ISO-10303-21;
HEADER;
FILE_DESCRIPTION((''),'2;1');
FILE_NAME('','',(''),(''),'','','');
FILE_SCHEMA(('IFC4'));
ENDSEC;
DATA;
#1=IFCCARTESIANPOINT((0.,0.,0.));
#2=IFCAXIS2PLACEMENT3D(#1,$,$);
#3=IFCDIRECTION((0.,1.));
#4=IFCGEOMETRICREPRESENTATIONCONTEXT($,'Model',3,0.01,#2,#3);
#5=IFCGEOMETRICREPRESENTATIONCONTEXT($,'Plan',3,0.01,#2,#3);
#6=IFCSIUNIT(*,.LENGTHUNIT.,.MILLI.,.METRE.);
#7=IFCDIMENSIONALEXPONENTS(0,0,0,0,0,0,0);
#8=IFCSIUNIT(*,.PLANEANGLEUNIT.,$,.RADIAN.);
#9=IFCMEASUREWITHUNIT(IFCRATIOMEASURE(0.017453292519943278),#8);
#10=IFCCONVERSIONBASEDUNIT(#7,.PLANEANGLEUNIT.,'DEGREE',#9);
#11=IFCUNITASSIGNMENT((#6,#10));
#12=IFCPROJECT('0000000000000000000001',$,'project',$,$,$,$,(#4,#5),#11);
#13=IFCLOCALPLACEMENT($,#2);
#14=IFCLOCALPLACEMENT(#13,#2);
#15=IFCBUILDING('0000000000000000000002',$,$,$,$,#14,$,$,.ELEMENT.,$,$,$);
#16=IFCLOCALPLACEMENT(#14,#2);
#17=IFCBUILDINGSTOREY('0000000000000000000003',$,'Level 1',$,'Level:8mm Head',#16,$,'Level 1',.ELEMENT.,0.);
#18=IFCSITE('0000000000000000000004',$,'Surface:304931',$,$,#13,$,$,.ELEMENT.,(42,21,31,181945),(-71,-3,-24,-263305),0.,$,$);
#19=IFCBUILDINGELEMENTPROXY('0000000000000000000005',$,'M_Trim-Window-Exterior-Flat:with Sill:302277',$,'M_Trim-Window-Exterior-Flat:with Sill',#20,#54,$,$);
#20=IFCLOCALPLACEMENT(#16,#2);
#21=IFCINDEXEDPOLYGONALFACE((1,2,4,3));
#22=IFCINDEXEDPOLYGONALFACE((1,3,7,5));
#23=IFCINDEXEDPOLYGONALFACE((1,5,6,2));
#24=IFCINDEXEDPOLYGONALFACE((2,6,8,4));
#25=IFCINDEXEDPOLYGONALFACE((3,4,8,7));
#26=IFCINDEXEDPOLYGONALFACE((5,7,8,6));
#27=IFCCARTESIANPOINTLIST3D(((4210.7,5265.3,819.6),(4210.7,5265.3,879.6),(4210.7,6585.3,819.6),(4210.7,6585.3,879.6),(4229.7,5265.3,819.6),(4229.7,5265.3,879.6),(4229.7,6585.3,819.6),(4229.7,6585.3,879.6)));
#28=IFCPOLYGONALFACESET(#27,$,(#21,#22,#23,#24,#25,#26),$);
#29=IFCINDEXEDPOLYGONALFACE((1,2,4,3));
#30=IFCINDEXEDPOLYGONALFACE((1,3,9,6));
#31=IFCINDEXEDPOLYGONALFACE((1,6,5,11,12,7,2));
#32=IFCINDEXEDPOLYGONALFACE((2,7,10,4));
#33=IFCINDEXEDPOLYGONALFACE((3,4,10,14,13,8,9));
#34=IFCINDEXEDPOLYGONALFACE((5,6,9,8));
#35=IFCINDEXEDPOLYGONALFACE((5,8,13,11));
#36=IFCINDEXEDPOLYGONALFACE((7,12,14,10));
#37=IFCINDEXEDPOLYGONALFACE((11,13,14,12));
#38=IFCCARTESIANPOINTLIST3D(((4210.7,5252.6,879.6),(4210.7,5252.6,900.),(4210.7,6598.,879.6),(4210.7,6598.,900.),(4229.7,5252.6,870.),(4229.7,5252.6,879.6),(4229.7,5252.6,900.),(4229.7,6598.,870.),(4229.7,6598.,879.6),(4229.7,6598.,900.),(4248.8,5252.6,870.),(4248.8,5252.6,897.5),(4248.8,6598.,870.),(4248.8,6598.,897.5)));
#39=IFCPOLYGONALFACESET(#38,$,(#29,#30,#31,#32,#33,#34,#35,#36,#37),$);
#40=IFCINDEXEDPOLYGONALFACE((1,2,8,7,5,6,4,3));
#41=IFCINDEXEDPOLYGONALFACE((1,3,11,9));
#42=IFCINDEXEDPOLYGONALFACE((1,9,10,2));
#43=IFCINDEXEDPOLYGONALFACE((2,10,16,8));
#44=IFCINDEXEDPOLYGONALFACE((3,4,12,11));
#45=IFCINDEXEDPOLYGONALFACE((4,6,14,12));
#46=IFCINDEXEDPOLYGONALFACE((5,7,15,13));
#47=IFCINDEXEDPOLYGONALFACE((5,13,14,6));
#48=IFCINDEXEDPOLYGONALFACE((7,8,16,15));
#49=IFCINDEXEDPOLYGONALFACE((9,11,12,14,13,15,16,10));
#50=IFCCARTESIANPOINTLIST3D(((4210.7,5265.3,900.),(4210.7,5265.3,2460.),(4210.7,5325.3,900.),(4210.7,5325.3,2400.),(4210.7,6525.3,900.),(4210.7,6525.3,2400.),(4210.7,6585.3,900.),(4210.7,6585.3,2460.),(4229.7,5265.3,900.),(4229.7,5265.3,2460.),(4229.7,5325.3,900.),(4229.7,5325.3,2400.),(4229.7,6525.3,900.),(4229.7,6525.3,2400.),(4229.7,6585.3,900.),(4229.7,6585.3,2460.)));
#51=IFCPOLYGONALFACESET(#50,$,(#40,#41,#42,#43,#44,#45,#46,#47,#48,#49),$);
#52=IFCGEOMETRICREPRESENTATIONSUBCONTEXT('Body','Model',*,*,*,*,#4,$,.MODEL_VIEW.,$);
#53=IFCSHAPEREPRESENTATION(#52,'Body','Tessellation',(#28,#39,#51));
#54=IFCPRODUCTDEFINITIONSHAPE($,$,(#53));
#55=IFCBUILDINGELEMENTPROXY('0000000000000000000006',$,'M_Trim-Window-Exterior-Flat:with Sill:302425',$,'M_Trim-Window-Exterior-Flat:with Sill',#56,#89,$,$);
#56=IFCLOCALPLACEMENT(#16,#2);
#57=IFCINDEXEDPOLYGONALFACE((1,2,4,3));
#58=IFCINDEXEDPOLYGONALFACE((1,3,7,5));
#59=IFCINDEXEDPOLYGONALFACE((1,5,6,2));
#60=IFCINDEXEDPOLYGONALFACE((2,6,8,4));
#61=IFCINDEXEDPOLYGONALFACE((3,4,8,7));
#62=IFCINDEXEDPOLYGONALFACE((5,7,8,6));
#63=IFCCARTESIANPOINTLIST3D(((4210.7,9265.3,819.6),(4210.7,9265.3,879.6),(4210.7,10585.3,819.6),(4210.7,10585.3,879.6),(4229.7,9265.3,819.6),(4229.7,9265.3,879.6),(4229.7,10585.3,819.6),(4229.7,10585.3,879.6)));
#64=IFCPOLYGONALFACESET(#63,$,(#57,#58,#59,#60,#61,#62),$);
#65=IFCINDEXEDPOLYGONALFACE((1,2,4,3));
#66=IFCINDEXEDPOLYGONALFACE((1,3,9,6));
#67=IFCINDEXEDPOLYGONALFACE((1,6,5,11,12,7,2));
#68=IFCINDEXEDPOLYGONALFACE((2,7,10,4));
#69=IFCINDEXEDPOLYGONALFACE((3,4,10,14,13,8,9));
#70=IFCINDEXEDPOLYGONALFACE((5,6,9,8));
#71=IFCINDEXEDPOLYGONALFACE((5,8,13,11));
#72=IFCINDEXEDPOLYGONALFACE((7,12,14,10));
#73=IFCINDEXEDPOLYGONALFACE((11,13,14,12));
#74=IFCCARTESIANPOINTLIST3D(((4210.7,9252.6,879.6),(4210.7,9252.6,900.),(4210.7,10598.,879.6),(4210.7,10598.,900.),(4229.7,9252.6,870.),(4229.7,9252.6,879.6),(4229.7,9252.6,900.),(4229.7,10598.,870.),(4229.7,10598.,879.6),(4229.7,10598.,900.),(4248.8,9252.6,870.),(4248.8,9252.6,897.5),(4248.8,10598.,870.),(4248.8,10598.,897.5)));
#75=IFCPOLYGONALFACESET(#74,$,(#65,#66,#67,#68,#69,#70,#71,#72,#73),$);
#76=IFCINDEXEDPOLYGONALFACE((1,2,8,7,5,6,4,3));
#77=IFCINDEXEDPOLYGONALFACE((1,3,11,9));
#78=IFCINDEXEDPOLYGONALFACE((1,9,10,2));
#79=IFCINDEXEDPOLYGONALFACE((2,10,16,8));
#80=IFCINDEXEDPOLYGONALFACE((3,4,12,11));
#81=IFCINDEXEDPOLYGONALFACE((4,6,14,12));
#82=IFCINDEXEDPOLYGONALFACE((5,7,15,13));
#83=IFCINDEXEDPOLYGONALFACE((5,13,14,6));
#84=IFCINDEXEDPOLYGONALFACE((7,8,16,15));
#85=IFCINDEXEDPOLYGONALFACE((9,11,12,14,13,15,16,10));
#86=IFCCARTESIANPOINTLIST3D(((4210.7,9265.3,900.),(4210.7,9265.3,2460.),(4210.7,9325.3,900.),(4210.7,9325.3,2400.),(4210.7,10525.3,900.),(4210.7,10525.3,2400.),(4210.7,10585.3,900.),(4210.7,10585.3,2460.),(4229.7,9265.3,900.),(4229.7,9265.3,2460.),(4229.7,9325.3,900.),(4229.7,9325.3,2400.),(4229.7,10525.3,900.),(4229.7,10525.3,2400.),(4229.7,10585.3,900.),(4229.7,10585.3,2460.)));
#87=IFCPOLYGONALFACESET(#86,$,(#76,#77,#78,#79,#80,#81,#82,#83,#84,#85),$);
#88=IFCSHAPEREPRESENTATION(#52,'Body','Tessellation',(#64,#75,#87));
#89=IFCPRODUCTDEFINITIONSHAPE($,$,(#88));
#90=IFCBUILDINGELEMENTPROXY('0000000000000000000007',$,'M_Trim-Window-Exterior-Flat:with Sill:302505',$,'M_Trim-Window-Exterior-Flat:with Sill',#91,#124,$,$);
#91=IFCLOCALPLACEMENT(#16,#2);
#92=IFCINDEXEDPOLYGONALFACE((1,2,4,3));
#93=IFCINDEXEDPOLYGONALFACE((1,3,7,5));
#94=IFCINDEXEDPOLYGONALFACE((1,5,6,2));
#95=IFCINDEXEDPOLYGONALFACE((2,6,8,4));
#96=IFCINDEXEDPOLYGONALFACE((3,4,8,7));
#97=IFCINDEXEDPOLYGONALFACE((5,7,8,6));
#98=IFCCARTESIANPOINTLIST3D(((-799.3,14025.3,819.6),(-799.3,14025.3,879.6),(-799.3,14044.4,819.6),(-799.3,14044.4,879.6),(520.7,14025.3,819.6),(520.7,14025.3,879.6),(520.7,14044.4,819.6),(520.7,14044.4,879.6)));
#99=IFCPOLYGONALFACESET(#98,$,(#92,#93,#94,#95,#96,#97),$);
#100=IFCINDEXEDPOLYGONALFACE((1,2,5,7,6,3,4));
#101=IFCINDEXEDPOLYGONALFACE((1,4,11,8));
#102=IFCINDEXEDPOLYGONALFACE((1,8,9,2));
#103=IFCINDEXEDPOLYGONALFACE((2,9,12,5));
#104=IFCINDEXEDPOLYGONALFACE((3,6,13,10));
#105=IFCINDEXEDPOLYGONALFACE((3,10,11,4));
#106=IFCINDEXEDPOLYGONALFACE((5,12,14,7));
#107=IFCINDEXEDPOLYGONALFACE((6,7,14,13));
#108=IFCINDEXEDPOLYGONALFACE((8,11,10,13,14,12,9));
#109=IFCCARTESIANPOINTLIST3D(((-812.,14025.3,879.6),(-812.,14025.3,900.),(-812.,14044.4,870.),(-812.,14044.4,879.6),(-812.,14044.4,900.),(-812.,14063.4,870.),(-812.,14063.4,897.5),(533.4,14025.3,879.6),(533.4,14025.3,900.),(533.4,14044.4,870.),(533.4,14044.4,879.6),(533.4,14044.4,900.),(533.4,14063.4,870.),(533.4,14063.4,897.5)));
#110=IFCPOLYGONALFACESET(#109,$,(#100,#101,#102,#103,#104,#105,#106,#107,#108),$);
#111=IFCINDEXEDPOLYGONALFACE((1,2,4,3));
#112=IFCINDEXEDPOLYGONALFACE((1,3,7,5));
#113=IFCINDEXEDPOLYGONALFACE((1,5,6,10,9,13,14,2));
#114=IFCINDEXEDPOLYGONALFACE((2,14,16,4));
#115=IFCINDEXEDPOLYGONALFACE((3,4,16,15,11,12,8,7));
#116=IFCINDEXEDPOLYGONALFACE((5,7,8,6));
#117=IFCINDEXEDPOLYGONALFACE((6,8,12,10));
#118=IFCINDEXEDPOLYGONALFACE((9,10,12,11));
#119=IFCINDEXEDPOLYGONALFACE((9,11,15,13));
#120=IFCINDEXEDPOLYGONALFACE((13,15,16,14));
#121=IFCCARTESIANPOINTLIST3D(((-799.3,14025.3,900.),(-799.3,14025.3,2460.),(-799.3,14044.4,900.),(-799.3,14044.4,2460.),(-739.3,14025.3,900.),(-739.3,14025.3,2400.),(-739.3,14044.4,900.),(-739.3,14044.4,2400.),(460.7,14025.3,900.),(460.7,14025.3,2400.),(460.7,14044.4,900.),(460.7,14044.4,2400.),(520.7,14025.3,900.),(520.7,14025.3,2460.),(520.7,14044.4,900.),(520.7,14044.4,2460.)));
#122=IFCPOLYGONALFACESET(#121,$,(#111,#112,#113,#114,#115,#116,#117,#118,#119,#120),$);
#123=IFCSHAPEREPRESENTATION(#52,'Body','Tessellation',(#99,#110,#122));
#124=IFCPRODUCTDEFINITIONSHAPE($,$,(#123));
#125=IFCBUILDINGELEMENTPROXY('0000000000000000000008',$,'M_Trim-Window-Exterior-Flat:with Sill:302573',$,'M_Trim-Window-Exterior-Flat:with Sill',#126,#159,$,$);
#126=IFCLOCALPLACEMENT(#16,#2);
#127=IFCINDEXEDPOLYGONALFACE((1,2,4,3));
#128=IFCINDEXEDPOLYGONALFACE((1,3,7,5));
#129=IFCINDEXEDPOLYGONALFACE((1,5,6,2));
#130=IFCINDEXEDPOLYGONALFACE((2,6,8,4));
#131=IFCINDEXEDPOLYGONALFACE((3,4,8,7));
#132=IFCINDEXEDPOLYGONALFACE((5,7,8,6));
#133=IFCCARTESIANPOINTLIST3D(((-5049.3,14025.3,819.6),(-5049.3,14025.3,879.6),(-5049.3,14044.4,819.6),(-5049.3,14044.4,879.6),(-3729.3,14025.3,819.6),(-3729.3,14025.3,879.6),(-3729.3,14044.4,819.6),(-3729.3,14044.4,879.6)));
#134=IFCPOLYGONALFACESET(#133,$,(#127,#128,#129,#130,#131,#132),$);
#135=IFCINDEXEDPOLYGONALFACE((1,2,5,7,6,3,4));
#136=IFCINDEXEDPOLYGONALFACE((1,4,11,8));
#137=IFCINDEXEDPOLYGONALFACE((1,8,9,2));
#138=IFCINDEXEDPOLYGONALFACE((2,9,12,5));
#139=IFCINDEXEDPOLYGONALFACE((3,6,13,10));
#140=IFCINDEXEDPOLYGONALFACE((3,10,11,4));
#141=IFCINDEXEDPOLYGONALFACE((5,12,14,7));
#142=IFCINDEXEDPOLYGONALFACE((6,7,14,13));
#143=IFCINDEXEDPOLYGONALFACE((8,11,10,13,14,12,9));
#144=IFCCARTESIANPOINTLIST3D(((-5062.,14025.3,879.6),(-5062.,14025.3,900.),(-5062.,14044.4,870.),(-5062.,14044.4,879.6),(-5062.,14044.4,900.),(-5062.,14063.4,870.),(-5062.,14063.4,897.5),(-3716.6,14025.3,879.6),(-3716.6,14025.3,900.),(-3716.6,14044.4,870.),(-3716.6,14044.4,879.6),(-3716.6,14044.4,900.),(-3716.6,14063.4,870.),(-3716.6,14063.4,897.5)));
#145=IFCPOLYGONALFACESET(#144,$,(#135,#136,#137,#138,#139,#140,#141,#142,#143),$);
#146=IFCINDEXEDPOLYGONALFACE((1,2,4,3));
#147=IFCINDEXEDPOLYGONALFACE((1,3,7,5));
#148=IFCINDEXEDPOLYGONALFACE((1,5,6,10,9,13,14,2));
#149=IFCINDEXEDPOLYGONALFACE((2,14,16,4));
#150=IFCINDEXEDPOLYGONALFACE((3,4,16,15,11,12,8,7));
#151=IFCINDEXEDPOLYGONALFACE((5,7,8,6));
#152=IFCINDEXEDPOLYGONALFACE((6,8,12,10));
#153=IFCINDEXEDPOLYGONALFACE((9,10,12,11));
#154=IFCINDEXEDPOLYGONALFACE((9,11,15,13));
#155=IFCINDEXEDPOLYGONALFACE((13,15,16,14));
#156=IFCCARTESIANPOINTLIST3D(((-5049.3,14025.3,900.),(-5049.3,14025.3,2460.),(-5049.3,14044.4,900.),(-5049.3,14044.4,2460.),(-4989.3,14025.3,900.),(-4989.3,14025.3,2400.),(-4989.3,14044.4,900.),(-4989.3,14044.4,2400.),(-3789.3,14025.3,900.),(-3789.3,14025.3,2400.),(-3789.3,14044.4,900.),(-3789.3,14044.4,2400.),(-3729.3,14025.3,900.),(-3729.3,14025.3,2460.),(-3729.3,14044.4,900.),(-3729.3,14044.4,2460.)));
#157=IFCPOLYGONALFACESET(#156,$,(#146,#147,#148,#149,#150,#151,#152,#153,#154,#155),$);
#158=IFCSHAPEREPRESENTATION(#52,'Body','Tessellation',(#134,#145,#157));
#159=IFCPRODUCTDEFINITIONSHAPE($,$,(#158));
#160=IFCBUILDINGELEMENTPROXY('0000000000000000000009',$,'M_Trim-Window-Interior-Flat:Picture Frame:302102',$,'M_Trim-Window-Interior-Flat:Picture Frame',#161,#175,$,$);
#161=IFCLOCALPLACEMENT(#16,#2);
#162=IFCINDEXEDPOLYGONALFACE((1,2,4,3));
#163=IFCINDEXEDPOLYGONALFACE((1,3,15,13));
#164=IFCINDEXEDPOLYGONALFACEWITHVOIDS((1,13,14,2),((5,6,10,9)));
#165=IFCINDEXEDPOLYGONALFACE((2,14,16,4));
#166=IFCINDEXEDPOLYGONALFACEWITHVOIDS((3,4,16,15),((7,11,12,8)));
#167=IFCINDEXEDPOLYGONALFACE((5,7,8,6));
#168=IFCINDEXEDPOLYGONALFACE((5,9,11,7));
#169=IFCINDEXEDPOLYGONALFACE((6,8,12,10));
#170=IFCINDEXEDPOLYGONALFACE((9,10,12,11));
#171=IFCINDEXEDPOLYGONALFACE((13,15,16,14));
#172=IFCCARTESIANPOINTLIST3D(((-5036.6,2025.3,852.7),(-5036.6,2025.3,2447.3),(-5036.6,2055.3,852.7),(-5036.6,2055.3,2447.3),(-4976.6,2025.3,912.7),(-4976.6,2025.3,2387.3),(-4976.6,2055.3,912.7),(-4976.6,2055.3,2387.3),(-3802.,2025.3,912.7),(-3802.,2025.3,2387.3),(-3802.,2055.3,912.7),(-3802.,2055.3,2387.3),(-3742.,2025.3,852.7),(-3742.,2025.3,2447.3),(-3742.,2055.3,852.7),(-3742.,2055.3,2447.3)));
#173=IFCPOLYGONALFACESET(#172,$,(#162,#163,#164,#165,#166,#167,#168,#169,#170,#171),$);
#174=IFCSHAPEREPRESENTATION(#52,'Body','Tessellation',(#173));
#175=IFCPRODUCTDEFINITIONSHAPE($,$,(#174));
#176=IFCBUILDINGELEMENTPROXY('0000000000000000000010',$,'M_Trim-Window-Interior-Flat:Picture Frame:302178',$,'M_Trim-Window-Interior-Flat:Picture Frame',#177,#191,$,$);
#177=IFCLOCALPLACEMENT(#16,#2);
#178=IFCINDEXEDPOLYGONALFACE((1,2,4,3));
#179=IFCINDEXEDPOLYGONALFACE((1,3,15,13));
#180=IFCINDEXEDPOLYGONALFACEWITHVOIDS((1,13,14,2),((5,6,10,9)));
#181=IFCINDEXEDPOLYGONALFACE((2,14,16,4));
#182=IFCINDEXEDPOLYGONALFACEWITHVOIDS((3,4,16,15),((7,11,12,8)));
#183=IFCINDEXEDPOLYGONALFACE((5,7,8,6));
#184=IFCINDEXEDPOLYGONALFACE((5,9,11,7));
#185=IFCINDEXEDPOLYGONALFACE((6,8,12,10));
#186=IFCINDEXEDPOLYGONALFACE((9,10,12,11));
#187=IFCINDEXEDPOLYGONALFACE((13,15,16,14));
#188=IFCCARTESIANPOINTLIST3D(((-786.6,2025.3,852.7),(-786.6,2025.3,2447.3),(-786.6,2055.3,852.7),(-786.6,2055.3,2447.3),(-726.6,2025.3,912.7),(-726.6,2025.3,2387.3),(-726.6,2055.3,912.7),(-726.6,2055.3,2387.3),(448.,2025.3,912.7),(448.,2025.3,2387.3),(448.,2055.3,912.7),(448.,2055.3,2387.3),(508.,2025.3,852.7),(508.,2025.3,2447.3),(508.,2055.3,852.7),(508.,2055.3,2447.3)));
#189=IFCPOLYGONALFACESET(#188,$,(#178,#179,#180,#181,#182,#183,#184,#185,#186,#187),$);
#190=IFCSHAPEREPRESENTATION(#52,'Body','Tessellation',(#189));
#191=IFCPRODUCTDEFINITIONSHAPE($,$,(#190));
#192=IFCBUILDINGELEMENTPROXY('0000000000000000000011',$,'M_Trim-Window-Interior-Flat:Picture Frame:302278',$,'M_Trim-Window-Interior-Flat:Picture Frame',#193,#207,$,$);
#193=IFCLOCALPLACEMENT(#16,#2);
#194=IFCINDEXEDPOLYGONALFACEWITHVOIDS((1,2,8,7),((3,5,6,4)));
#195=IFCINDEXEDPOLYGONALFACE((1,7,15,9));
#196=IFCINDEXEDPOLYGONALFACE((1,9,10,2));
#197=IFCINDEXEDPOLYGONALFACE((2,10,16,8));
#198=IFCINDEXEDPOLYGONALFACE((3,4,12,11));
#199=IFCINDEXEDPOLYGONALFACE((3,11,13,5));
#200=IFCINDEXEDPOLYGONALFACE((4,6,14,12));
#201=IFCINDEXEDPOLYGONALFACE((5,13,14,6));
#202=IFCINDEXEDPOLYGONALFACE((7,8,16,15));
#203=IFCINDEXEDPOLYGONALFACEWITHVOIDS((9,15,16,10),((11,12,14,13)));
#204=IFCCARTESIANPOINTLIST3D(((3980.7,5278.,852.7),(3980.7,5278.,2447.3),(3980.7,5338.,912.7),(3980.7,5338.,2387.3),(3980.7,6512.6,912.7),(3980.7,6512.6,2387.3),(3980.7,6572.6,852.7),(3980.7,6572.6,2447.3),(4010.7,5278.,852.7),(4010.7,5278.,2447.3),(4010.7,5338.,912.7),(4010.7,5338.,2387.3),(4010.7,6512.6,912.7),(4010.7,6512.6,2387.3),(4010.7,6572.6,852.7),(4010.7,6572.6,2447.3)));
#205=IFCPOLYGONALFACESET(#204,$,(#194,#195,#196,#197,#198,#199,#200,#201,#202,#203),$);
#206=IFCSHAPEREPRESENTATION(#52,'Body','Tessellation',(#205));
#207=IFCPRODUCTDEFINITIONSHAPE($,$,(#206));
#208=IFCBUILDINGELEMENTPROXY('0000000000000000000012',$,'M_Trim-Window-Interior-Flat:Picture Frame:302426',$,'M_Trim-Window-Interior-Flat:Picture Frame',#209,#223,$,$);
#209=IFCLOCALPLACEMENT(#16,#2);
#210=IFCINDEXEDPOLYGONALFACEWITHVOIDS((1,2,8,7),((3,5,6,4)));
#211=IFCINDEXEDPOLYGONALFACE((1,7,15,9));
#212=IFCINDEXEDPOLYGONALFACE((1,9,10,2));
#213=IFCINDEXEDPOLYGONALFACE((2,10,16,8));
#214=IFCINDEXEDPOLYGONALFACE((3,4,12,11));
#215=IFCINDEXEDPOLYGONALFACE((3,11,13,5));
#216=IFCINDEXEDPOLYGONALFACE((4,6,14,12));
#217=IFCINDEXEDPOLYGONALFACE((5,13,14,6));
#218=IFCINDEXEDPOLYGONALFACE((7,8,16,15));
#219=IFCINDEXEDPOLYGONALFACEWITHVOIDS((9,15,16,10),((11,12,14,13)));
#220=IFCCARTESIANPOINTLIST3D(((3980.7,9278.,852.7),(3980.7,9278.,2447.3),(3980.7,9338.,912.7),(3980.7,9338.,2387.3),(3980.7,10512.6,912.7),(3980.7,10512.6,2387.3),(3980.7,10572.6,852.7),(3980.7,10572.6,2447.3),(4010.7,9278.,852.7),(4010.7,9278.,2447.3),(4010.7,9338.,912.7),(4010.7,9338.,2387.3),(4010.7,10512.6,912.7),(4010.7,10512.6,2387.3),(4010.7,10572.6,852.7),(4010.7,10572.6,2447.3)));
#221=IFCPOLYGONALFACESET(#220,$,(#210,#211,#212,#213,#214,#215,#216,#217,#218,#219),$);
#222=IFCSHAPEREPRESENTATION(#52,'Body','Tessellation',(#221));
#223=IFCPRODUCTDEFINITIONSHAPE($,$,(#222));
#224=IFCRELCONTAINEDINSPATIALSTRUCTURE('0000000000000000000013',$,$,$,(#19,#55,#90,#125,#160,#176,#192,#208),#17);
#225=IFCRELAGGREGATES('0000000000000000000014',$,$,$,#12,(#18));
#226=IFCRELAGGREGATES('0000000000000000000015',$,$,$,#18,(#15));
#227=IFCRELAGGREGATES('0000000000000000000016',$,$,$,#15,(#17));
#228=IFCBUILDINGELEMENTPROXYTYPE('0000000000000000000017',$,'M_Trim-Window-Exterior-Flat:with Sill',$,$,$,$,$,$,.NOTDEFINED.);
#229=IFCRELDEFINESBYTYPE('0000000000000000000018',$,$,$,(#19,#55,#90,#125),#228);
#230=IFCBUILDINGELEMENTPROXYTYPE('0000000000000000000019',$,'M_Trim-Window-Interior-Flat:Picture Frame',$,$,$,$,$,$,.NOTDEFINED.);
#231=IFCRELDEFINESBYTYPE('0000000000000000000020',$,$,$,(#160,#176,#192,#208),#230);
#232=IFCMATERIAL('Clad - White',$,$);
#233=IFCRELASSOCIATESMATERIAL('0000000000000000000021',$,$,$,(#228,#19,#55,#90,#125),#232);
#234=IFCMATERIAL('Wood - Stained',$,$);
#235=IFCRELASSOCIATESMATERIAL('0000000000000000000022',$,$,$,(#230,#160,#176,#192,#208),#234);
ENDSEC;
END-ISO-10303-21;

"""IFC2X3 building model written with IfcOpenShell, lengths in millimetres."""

from ifc_helpers import new_model, entity, si_unit, converted_unit, direction, frame, frame_2d, origin, place, context, subcontext, project, spatial, polyline, rectangle, outline, extrude, source, transform, mapped, material, type_object, type_shapes, element, save


model = new_model("IFC2X3")

# Units and contexts
model_context = context("Model", 3, precision=0.01, world=origin(), true_north=direction((0.0, 1.0)))
plan_context = context("Plan", 3, precision=0.01, world=origin(), true_north=direction((0.0, 1.0)))
body_context = subcontext(model_context, "Body", "Model", "MODEL_VIEW")
ifc_project = project(units=[si_unit("LENGTHUNIT", "METRE", prefix="MILLI"), converted_unit("PLANEANGLEUNIT", "DEGREE", entity("IfcRatioMeasure", 0.017453292519943278), si_unit("PLANEANGLEUNIT", "RADIAN"), dimensions=[0, 0, 0, 0, 0, 0, 0])], contexts=[model_context, plan_context])

# Site, building, storey
site_placement = place(None, origin())
site = spatial("IfcSite", under=ifc_project, at=site_placement, Name="Surface:304931", CompositionType="ELEMENT", RefLatitude=(42, 21, 31, 181945), RefLongitude=(-71, -3, -24, -263305), RefElevation=0.0)
building_placement = place(site_placement, origin())
building = spatial("IfcBuilding", under=site, at=building_placement, CompositionType="ELEMENT")
storey_placement = place(building_placement, origin())
storey = spatial("IfcBuildingStorey", under=building, at=storey_placement, Name="Level 1", ObjectType="Level:8mm Head", LongName="Level 1", CompositionType="ELEMENT", Elevation=0.0)

# Building element proxies
ifc_material_1 = material(Name="Clad - White")
ifc_material_2 = material(Name="Wood - Stained")
building_element_proxy_type_1 = type_object("IfcBuildingElementProxyType", Name="M_Trim-Window-Exterior-Flat:with Sill", PredefinedType="NOTDEFINED", material=ifc_material_1)
shared_shape_1 = source(origin(), body_context, "Body", "SweptSolid", [
    extrude(rectangle(XDim=1320.0, YDim=60.0, at=frame_2d((0.0, 0.0), x_axis=(1.0, 0.0))), frame((0.0, -1550.4, 0.0), z_axis=(0.0, 0.0, 1.0), x_axis=(-1.0, 0.0, 0.0)), (0.0, 0.0, 1.0), 19.0),
    extrude(outline(polyline([(-19.0, -15.2), (0.0, -15.2), (0.0, -5.7), (19.0, -5.7), (19.0, 14.8), (0.0, 14.8), (-19.0, 12.3), (-19.0, -15.2)])), frame((-672.7, -1514.8, 19.0), z_axis=(1.0, 0.0, 0.0), x_axis=(0.0, 0.0, -1.0)), (0.0, 0.0, 1.0), 1345.4),
    extrude(outline(polyline([(-795.0, -660.0), (765.0, -660.0), (765.0, -600.0), (-735.0, -600.0), (-735.0, 600.0), (765.0, 600.0), (765.0, 660.0), (-795.0, 660.0), (-795.0, -660.0)])), frame((0.0, -735.0, 0.0), z_axis=(0.0, 0.0, 1.0), x_axis=(0.0, -1.0, 0.0)), (0.0, 0.0, 1.0), 19.0),
])
type_shapes(building_element_proxy_type_1, [shared_shape_1])
for number, where, z_axis, x_axis, name in (
    (1, (4210.7, 5925.3, 2400.0), (1.0, 0.0, 0.0), (0.0, 1.0, 0.0), "M_Trim-Window-Exterior-Flat:with Sill:302277"),
    (2, (4210.7, 9925.3, 2400.0), (1.0, 0.0, 0.0), (0.0, 1.0, 0.0), "M_Trim-Window-Exterior-Flat:with Sill:302425"),
    (3, (-139.3, 14025.3, 2400.0), (0.0, 1.0, 0.0), (-1.0, 0.0, 0.0), "M_Trim-Window-Exterior-Flat:with Sill:302505"),
    (4, (-4389.3, 14025.3, 2400.0), (0.0, 1.0, 0.0), (-1.0, 0.0, 0.0), "M_Trim-Window-Exterior-Flat:with Sill:302573"),
):
    element("IfcBuildingElementProxy", number, at=place(storey_placement, frame(where, z_axis=z_axis, x_axis=x_axis)), inside=storey, type_object=building_element_proxy_type_1, material=ifc_material_1, Name=name, ObjectType="M_Trim-Window-Exterior-Flat:with Sill", context=body_context, shape_type="MappedRepresentation", body=[
        mapped(shared_shape_1, transform((0.0, 0.0, 0.0), scale=1.0)),
    ])
building_element_proxy_type_2 = type_object("IfcBuildingElementProxyType", Name="M_Trim-Window-Interior-Flat:Picture Frame", PredefinedType="NOTDEFINED", material=ifc_material_2)
shared_shape_2 = source(origin(), body_context, "Body", "SweptSolid", [
    extrude(outline(polyline([(-647.3, -797.3), (647.3, -797.3), (647.3, 797.3), (-647.3, 797.3), (-647.3, -797.3)]), holes=[polyline([(-587.3, -737.3), (-587.3, 737.3), (587.3, 737.3), (587.3, -737.3), (-587.3, -737.3)])]), frame((0.0, -750.0, 0.0), z_axis=(0.0, 0.0, 1.0), x_axis=(-1.0, 0.0, 0.0)), (0.0, 0.0, 1.0), 30.0),
])
type_shapes(building_element_proxy_type_2, [shared_shape_2])
for number, where, z_axis, x_axis, name in (
    (5, (-4389.3, 2025.3, 2400.0), (0.0, 1.0, 0.0), (-1.0, 0.0, 0.0), "M_Trim-Window-Interior-Flat:Picture Frame:302102"),
    (6, (-139.3, 2025.3, 2400.0), (0.0, 1.0, 0.0), (-1.0, 0.0, 0.0), "M_Trim-Window-Interior-Flat:Picture Frame:302178"),
    (7, (4010.7, 5925.3, 2400.0), (-1.0, 0.0, 0.0), (0.0, -1.0, 0.0), "M_Trim-Window-Interior-Flat:Picture Frame:302278"),
    (8, (4010.7, 9925.3, 2400.0), (-1.0, 0.0, 0.0), (0.0, -1.0, 0.0), "M_Trim-Window-Interior-Flat:Picture Frame:302426"),
):
    element("IfcBuildingElementProxy", number, at=place(storey_placement, frame(where, z_axis=z_axis, x_axis=x_axis)), inside=storey, type_object=building_element_proxy_type_2, material=ifc_material_2, Name=name, ObjectType="M_Trim-Window-Interior-Flat:Picture Frame", context=body_context, shape_type="MappedRepresentation", body=[
        mapped(shared_shape_2, transform((0.0, 0.0, 0.0), scale=1.0)),
    ])

save(model, "model.ifc")
